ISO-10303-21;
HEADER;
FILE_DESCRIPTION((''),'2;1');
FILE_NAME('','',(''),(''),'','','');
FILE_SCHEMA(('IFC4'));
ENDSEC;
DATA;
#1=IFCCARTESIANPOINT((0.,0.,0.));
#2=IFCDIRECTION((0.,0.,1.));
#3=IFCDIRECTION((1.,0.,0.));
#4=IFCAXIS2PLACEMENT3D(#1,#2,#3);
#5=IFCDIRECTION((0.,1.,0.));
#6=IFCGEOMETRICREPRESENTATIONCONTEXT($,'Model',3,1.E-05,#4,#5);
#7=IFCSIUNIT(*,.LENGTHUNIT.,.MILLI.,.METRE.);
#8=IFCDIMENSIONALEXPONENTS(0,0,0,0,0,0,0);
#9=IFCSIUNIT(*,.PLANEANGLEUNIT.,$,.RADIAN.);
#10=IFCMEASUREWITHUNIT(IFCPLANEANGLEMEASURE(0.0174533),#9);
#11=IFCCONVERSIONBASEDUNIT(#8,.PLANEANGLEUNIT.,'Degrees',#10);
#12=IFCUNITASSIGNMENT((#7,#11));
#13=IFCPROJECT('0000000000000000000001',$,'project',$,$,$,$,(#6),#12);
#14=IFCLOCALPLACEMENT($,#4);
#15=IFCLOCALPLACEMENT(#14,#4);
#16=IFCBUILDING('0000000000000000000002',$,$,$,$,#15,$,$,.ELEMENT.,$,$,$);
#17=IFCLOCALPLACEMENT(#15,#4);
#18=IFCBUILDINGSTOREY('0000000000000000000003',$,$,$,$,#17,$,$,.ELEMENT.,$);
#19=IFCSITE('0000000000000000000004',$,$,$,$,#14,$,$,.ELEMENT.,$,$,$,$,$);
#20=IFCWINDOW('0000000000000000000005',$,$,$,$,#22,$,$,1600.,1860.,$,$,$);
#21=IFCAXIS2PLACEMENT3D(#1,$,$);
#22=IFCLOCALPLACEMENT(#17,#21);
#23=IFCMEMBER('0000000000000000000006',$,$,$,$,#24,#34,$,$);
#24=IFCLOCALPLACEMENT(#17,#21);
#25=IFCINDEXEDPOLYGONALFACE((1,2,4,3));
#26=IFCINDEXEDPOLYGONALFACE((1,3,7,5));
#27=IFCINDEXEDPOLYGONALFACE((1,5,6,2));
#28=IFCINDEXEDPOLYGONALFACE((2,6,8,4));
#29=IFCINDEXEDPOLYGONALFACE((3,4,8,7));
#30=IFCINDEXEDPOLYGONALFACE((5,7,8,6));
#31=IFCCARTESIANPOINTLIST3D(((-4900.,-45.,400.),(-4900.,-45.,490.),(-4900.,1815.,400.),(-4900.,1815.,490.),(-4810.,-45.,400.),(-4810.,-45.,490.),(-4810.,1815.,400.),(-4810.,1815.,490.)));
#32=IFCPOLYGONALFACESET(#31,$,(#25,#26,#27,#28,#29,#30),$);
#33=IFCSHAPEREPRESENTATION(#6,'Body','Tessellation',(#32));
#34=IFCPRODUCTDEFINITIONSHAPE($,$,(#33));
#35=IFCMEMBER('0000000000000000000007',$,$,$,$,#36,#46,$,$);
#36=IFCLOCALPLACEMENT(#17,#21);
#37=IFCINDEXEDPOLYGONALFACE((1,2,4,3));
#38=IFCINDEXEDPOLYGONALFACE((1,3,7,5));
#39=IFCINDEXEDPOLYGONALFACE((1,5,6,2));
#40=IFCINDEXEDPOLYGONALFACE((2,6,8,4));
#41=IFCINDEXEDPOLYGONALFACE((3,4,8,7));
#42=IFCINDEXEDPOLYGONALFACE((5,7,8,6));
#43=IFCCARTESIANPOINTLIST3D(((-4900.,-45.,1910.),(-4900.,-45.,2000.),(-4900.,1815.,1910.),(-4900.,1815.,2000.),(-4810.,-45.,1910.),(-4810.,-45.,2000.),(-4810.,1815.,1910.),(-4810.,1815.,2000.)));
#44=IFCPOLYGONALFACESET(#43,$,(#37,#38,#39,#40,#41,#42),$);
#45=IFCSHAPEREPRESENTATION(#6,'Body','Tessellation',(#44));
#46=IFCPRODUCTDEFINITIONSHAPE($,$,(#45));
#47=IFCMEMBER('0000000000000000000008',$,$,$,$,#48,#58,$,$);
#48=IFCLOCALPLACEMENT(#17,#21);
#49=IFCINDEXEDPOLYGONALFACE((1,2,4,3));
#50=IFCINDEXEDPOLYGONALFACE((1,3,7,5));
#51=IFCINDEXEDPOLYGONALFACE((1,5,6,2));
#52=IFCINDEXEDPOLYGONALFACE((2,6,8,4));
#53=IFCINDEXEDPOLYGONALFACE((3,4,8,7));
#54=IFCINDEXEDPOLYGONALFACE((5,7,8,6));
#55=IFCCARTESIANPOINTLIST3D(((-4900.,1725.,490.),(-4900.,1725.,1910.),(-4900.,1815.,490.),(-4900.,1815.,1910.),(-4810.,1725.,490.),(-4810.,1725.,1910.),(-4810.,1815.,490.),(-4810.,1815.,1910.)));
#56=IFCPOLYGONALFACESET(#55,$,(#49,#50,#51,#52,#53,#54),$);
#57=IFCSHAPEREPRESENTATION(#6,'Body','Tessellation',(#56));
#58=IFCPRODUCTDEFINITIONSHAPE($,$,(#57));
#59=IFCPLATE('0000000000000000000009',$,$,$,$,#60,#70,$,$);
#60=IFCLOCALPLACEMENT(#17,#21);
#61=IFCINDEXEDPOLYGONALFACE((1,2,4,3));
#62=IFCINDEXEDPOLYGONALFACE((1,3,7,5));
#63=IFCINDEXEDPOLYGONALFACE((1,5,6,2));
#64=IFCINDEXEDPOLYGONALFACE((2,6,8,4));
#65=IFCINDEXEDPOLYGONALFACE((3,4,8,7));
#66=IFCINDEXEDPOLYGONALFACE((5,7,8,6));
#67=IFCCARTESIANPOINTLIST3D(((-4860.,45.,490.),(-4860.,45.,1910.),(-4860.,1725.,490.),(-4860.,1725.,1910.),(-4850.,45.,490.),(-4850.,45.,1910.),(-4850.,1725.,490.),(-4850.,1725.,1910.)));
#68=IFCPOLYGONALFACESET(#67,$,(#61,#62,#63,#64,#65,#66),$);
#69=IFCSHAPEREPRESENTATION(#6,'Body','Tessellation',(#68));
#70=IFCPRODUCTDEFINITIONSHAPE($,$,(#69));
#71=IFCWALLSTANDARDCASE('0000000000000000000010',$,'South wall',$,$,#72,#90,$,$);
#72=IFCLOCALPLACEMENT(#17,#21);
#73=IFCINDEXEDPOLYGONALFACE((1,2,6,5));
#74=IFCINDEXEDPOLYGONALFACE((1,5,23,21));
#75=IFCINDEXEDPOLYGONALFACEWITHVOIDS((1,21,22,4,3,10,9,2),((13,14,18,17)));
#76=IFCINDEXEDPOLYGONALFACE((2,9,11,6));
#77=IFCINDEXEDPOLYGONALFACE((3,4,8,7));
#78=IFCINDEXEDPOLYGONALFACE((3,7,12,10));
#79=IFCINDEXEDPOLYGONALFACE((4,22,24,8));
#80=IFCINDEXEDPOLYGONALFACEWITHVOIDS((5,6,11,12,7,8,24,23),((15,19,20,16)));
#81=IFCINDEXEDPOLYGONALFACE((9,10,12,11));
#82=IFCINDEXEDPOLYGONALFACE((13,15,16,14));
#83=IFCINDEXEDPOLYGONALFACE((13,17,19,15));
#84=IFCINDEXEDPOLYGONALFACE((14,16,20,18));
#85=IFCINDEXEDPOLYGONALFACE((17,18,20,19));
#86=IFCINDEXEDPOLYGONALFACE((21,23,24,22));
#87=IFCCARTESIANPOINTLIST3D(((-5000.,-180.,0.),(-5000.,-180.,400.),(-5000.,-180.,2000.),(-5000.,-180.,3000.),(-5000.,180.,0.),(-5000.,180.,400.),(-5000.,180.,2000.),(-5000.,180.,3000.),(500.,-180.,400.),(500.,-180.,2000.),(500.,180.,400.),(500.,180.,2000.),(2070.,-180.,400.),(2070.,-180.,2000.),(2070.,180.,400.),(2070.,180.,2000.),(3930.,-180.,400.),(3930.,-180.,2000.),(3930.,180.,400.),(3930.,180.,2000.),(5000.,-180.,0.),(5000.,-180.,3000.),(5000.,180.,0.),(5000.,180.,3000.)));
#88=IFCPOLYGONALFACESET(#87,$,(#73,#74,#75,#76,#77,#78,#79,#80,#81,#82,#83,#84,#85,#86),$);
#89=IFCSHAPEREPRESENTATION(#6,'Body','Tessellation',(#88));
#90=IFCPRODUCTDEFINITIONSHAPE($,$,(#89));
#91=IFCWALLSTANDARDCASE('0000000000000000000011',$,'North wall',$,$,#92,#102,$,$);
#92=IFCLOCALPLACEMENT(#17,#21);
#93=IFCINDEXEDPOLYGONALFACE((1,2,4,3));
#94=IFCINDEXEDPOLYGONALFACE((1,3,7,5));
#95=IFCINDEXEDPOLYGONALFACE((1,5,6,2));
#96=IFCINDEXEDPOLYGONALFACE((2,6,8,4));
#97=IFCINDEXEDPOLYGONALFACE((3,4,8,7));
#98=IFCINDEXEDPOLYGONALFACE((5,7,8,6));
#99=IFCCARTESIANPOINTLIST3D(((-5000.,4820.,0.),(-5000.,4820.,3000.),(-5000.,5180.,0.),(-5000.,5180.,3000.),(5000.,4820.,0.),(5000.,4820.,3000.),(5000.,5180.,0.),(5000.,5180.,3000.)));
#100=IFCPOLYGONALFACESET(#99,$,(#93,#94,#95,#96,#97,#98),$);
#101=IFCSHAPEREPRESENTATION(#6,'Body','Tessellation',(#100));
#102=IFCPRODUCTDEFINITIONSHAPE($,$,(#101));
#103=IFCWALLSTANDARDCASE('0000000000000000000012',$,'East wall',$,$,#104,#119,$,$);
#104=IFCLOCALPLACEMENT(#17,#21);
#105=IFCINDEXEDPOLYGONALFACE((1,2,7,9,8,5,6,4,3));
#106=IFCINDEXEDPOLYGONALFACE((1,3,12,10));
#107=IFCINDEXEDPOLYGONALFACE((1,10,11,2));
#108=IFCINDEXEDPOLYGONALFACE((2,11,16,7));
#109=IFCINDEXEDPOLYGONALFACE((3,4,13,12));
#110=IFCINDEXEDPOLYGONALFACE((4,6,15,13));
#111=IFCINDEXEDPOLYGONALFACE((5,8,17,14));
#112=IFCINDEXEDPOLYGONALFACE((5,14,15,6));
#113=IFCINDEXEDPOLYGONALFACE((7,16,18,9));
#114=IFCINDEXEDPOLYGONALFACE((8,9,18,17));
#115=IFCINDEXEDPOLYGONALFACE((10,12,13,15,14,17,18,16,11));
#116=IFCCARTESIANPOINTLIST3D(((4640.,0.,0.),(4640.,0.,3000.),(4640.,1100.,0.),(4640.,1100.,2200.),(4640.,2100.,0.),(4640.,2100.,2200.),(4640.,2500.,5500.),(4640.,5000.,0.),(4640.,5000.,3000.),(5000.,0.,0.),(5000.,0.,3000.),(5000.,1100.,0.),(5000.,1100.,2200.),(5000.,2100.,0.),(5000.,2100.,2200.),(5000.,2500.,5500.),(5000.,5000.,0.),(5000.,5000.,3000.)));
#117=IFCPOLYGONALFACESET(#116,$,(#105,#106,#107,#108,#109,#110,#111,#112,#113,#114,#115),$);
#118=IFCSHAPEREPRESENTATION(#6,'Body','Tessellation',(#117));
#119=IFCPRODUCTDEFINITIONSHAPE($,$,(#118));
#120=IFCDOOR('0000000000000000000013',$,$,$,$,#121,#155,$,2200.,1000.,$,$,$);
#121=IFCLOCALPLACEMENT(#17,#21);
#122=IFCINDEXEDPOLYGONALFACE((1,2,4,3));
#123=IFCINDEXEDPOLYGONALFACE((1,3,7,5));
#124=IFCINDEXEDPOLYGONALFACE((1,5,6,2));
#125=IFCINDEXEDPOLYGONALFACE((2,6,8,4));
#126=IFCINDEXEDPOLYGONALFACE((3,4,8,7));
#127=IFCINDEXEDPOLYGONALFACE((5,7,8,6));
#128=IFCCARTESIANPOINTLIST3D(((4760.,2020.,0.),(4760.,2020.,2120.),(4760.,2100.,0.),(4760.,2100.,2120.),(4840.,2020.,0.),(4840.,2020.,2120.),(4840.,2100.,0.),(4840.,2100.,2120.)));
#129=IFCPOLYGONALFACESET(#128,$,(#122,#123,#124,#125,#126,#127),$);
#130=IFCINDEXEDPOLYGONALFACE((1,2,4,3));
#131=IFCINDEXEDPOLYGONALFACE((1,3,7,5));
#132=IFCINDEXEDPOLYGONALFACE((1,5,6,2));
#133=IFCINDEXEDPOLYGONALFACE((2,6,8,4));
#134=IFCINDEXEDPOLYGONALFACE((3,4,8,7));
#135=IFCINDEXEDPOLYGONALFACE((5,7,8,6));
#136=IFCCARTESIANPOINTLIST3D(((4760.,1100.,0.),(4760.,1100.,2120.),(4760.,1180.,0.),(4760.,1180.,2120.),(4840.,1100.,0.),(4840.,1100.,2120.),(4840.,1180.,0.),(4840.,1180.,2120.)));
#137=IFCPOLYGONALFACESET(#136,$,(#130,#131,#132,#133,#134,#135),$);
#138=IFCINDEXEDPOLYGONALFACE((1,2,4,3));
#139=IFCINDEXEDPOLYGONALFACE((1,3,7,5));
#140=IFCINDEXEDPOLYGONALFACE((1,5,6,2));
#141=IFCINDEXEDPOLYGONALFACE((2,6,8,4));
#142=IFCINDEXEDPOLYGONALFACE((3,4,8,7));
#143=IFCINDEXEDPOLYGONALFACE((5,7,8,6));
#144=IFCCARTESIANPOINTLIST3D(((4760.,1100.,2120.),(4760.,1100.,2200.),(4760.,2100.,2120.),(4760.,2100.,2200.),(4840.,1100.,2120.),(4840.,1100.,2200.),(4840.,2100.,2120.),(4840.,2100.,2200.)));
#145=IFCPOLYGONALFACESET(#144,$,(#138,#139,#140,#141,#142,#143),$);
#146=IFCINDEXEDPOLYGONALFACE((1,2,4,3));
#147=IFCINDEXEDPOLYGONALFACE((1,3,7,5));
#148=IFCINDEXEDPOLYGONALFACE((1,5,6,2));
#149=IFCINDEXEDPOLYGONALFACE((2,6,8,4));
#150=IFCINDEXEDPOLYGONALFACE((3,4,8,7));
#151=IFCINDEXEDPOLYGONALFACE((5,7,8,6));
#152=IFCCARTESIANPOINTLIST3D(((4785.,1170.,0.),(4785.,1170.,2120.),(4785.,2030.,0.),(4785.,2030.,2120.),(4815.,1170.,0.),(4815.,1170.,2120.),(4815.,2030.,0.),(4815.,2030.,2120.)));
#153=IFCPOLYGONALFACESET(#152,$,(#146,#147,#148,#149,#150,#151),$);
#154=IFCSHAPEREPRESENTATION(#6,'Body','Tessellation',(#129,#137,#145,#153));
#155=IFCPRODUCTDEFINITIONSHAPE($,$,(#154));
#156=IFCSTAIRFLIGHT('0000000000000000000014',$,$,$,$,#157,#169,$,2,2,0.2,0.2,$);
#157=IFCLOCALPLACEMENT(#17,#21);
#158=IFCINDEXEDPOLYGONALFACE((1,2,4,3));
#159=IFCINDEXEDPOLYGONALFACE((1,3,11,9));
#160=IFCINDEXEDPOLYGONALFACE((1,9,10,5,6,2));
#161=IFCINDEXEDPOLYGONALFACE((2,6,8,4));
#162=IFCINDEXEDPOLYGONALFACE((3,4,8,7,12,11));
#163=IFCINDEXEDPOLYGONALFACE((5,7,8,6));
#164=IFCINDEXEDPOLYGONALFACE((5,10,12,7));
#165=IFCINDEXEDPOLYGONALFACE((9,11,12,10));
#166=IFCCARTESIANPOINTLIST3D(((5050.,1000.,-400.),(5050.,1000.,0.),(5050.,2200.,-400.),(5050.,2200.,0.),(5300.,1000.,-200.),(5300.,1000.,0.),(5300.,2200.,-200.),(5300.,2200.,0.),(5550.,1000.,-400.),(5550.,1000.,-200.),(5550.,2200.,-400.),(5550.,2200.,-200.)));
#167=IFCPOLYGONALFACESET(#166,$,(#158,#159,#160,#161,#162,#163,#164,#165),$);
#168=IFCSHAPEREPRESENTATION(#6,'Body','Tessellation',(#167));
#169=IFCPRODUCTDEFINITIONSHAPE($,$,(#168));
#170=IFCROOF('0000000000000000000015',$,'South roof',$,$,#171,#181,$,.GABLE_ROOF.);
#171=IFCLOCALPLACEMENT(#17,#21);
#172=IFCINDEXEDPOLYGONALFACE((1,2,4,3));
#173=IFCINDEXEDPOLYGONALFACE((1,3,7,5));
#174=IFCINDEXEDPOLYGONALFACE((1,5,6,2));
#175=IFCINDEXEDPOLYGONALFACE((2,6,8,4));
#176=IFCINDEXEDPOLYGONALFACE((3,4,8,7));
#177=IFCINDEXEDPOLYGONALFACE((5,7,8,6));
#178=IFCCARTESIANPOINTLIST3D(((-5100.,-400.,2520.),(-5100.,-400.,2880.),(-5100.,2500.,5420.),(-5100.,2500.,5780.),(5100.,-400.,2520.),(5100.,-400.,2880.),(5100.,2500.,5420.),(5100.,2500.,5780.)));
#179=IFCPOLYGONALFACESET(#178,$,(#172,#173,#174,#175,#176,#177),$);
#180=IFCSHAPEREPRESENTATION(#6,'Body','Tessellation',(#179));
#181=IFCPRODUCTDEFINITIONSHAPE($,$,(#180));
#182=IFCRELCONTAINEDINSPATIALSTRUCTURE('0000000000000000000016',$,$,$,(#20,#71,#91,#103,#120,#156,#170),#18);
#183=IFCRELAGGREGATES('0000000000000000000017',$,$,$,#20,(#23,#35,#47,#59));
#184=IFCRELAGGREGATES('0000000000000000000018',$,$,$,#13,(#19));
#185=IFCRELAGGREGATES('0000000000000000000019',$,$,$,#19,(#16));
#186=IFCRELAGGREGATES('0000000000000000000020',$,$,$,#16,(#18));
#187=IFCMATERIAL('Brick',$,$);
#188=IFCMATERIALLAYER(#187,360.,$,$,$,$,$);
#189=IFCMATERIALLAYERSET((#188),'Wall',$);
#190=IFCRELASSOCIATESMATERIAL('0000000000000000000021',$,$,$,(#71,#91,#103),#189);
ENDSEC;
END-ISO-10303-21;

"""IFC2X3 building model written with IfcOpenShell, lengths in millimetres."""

from ifc_helpers import new_model, entity, si_unit, converted_unit, direction, frame, origin_with_axes, place, context, project, spatial, polyline, outline, extrude, clip, halfspace, material, layer, layer_set, layer_usage, element, fill, aggregate, save


model = new_model("IFC2X3")

# Units and contexts
model_context = context("Model", 3, precision=1e-05, world=origin_with_axes(), true_north=direction((0.0, 1.0, 0.0)))
ifc_project = project(units=[si_unit("LENGTHUNIT", "METRE", prefix="MILLI"), converted_unit("PLANEANGLEUNIT", "Degrees", entity("IfcPlaneAngleMeasure", 0.0174533), si_unit("PLANEANGLEUNIT", "RADIAN"), dimensions=[0, 0, 0, 0, 0, 0, 0])], contexts=[model_context])

# Site, building, storey
site_placement = place(None, origin_with_axes())
site = spatial("IfcSite", under=ifc_project, at=site_placement, CompositionType="ELEMENT")
building_placement = place(site_placement, origin_with_axes())
building = spatial("IfcBuilding", under=site, at=building_placement, CompositionType="ELEMENT")
storey_placement = place(building_placement, origin_with_axes())
storey = spatial("IfcBuildingStorey", under=building, at=storey_placement, CompositionType="ELEMENT")

# Window, members
window_1_placement = place(storey_placement, frame((-4810.0, -45.0, 400.0), z_axis=(0.0, 0.0, 1.0), x_axis=(0.0, 1.0, 0.0)))
window_1 = element("IfcWindow", 1, at=window_1_placement, inside=storey, OverallHeight=1600.0, OverallWidth=1860.0)
member_1_placement = place(window_1_placement, frame((930.0, 45.0, 0.0), z_axis=(0.0, 0.0, 1.0), x_axis=(1.0, 0.0, 0.0)))
member_1 = element("IfcMember", 2, at=member_1_placement, context=model_context, shape_type="SweptSolid", body=[
    extrude(outline(polyline([(-930.0, -45.0), (930.0, -45.0), (930.0, 45.0), (-930.0, 45.0), (-930.0, -45.0), (-930.0, -45.0)])), origin_with_axes(), (0.0, 0.0, 1.0), 90.0),
])
member_2_placement = place(window_1_placement, frame((930.0, 45.0, 1510.0), z_axis=(0.0, 0.0, 1.0), x_axis=(1.0, 0.0, 0.0)))
member_2 = element("IfcMember", 3, at=member_2_placement, context=model_context, shape_type="SweptSolid", body=[
    extrude(outline(polyline([(-930.0, -45.0), (930.0, -45.0), (930.0, 45.0), (-930.0, 45.0), (-930.0, -45.0), (-930.0, -45.0)])), origin_with_axes(), (0.0, 0.0, 1.0), 90.0),
])
member_3_placement = place(window_1_placement, frame((1815.0, 45.0, 90.0), z_axis=(0.0, 0.0, 1.0), x_axis=(1.0, 0.0, 0.0)))
member_3 = element("IfcMember", 4, at=member_3_placement, context=model_context, shape_type="SweptSolid", body=[
    extrude(outline(polyline([(-45.0, -45.0), (45.0, -45.0), (45.0, 45.0), (-45.0, 45.0), (-45.0, -45.0), (-45.0, -45.0)])), origin_with_axes(), (0.0, 0.0, 1.0), 1420.0),
])

# Plate
plate_1_placement = place(window_1_placement, frame((930.0, 45.0, 90.0), z_axis=(0.0, 0.0, 1.0), x_axis=(1.0, 0.0, 0.0)))
plate_1 = element("IfcPlate", 5, at=plate_1_placement, context=model_context, shape_type="SweptSolid", body=[
    extrude(outline(polyline([(-840.0, -5.0), (840.0, -5.0), (840.0, 5.0), (-840.0, 5.0), (-840.0, -5.0), (-840.0, -5.0)])), origin_with_axes(), (0.0, 0.0, 1.0), 1420.0),
])
aggregate(window_1, [member_1, member_2, member_3, plate_1])

# Wall, openings
ifc_material = material(Name="Brick")
ifc_layer = layer(ifc_material, 360.0)
ifc_layer_set = layer_set([ifc_layer], Name="Wall")
ifc_layer_usage = layer_usage(ifc_layer_set, "AXIS2", "POSITIVE", -180.0)
wall_1_placement = place(None, origin_with_axes())
wall_1 = element("IfcWallStandardCase", 6, at=wall_1_placement, inside=storey, material=ifc_layer_usage, Name="South wall", context=model_context, shape_type="SweptSolid", body=[
    extrude(outline(polyline([(-5000.0, -180.0), (5000.0, -180.0), (5000.0, 180.0), (-5000.0, 180.0), (-5000.0, -180.0), (-5000.0, -180.0)])), origin_with_axes(), (0.0, 0.0, 1.0), 3000.0),
])
opening_1_placement = place(None, frame((-2500.0, 0.0, 400.0), z_axis=(0.0, 0.0, 1.0), x_axis=(1.0, 0.0, 0.0)))
element("IfcOpeningElement", 7, at=opening_1_placement, cuts=wall_1, context=model_context, shape_type="SweptSolid", body=[
    extrude(outline(polyline([(-3000.0, -1815.0), (3000.0, -1815.0), (3000.0, 1815.0), (-3000.0, 1815.0), (-3000.0, -1815.0), (-3000.0, -1815.0)])), origin_with_axes(), (0.0, 0.0, 1.0), 1600.0),
])
opening_2_placement = place(None, frame((3000.0, 0.0, 400.0), z_axis=(0.0, 0.0, 1.0), x_axis=(1.0, 0.0, 0.0)))
element("IfcOpeningElement", 8, at=opening_2_placement, cuts=wall_1, context=model_context, shape_type="SweptSolid", body=[
    extrude(outline(polyline([(-930.0, -1500.0), (930.0, -1500.0), (930.0, 1500.0), (-930.0, 1500.0), (-930.0, -1500.0), (-930.0, -1500.0)])), origin_with_axes(), (0.0, 0.0, 1.0), 1600.0),
])

# Wall
wall_2_placement = place(storey_placement, frame((0.0, 5000.0, 0.0), z_axis=(0.0, 0.0, 1.0), x_axis=(1.0, 0.0, 0.0)))
element("IfcWallStandardCase", 9, at=wall_2_placement, inside=storey, material=ifc_layer_usage, Name="North wall", context=model_context, shape_type="SweptSolid", body=[
    extrude(outline(polyline([(-5000.0, -180.0), (5000.0, -180.0), (5000.0, 180.0), (-5000.0, 180.0), (-5000.0, -180.0), (-5000.0, -180.0)])), origin_with_axes(), (0.0, 0.0, 1.0), 3000.0),
])

# Wall, opening, door
wall_3_placement = place(storey_placement, frame((4820.0, 2500.0, 0.0), z_axis=(0.0, 0.0, 1.0), x_axis=(0.0, 1.0, 0.0)))
wall_3 = element("IfcWallStandardCase", 10, at=wall_3_placement, inside=storey, material=ifc_layer_usage, Name="East wall", context=model_context, shape_type="Clipping", body=[
    clip(clip(extrude(outline(polyline([(-2500.0, -180.0), (2500.0, -180.0), (2500.0, 180.0), (-2500.0, 180.0), (-2500.0, -180.0), (-2500.0, -180.0)])), origin_with_axes(), (0.0, 0.0, 1.0), 6000.0), halfspace(frame((-2500.0, 0.0, 3000.0), z_axis=(-1.0, 0.0, 1.0), x_axis=(1.0, 0.0, 0.0)), False)), halfspace(frame((2500.0, 0.0, 3000.0), z_axis=(1.0, 0.0, 1.0), x_axis=(1.0, 0.0, 0.0)), False)),
])
opening_3_placement = place(None, frame((4820.0, 1600.0, 0.0), z_axis=(0.0, 0.0, 1.0), x_axis=(1.0, 0.0, 0.0)))
opening_3 = element("IfcOpeningElement", 11, at=opening_3_placement, cuts=wall_3, context=model_context, shape_type="SweptSolid", body=[
    extrude(outline(polyline([(-500.0, -500.0), (500.0, -500.0), (500.0, 500.0), (-500.0, 500.0), (-500.0, -500.0), (-500.0, -500.0)])), origin_with_axes(), (0.0, 0.0, 1.0), 2200.0),
])
door_placement = place(storey_placement, frame((4800.0, 1600.0, 0.0), z_axis=(0.0, 0.0, 1.0), x_axis=(0.0, 1.0, 0.0)))
door = element("IfcDoor", 12, at=door_placement, inside=storey, OverallHeight=2200.0, OverallWidth=1000.0, context=model_context, shape_type="SweptSolid", body=[
    extrude(outline(polyline([(-40.0, -40.0), (40.0, -40.0), (40.0, 40.0), (-40.0, 40.0), (-40.0, -40.0), (-40.0, -40.0)])), frame((460.0, 0.0, 0.0), z_axis=(0.0, 0.0, 1.0), x_axis=(1.0, 0.0, 0.0)), (0.0, 0.0, 1.0), 2120.0),
    extrude(outline(polyline([(-40.0, -40.0), (40.0, -40.0), (40.0, 40.0), (-40.0, 40.0), (-40.0, -40.0), (-40.0, -40.0)])), frame((-460.0, 0.0, 0.0), z_axis=(0.0, 0.0, 1.0), x_axis=(1.0, 0.0, 0.0)), (0.0, 0.0, 1.0), 2120.0),
    extrude(outline(polyline([(-500.0, -40.0), (500.0, -40.0), (500.0, 40.0), (-500.0, 40.0), (-500.0, -40.0), (-500.0, -40.0)])), frame((0.0, 0.0, 2120.0), z_axis=(0.0, 0.0, 1.0), x_axis=(1.0, 0.0, 0.0)), (0.0, 0.0, 1.0), 80.0),
    extrude(outline(polyline([(-430.0, -15.0), (430.0, -15.0), (430.0, 15.0), (-430.0, 15.0), (-430.0, -15.0), (-430.0, -15.0)])), origin_with_axes(), (0.0, 0.0, 1.0), 2120.0),
])
fill(opening_3, door)

# Stair flight
stair_flight_placement = place(storey_placement, frame((5050.0, 1000.0, 0.0), z_axis=(0.0, 1.0, 0.0), x_axis=(1.0, 0.0, 0.0)))
element("IfcStairFlight", 13, at=stair_flight_placement, inside=storey, NumberOfRiser=2, NumberOfTreads=2, RiserHeight=0.2, TreadLength=0.2, context=model_context, shape_type="SweptSolid", body=[
    extrude(outline(polyline([(0.0, 0.0), (250.0, 0.0), (250.0, 200.0), (500.0, 200.0), (500.0, 400.0), (0.0, 400.0), (0.0, 0.0)])), origin_with_axes(), (0.0, 0.0, 1.0), 1200.0),
])

# Roof
for number, where, z_axis, x_axis, name in (
    (14, (0.0, -400.0, 2700.0), (0.0, 0.0, 1.0), (1.0, 0.0, 0.0), "South roof"),
):
    element("IfcRoof", number, at=place(storey_placement, frame(where, z_axis=z_axis, x_axis=x_axis)), inside=storey, Name=name, ShapeType="GABLE_ROOF", context=model_context, shape_type="SweptSolid", body=[
        extrude(outline(polyline([(-5100.0, -180.0), (5100.0, -180.0), (5100.0, 180.0), (-5100.0, 180.0), (-5100.0, -180.0), (-5100.0, -180.0)])), frame((0.0, 0.0, 0.0), z_axis=(0.0, 1.0, 0.0), x_axis=(1.0, 0.0, 0.0)), (0.0, -0.707107, 0.707107), 4101.2),
    ])

save(model, "model.ifc")
